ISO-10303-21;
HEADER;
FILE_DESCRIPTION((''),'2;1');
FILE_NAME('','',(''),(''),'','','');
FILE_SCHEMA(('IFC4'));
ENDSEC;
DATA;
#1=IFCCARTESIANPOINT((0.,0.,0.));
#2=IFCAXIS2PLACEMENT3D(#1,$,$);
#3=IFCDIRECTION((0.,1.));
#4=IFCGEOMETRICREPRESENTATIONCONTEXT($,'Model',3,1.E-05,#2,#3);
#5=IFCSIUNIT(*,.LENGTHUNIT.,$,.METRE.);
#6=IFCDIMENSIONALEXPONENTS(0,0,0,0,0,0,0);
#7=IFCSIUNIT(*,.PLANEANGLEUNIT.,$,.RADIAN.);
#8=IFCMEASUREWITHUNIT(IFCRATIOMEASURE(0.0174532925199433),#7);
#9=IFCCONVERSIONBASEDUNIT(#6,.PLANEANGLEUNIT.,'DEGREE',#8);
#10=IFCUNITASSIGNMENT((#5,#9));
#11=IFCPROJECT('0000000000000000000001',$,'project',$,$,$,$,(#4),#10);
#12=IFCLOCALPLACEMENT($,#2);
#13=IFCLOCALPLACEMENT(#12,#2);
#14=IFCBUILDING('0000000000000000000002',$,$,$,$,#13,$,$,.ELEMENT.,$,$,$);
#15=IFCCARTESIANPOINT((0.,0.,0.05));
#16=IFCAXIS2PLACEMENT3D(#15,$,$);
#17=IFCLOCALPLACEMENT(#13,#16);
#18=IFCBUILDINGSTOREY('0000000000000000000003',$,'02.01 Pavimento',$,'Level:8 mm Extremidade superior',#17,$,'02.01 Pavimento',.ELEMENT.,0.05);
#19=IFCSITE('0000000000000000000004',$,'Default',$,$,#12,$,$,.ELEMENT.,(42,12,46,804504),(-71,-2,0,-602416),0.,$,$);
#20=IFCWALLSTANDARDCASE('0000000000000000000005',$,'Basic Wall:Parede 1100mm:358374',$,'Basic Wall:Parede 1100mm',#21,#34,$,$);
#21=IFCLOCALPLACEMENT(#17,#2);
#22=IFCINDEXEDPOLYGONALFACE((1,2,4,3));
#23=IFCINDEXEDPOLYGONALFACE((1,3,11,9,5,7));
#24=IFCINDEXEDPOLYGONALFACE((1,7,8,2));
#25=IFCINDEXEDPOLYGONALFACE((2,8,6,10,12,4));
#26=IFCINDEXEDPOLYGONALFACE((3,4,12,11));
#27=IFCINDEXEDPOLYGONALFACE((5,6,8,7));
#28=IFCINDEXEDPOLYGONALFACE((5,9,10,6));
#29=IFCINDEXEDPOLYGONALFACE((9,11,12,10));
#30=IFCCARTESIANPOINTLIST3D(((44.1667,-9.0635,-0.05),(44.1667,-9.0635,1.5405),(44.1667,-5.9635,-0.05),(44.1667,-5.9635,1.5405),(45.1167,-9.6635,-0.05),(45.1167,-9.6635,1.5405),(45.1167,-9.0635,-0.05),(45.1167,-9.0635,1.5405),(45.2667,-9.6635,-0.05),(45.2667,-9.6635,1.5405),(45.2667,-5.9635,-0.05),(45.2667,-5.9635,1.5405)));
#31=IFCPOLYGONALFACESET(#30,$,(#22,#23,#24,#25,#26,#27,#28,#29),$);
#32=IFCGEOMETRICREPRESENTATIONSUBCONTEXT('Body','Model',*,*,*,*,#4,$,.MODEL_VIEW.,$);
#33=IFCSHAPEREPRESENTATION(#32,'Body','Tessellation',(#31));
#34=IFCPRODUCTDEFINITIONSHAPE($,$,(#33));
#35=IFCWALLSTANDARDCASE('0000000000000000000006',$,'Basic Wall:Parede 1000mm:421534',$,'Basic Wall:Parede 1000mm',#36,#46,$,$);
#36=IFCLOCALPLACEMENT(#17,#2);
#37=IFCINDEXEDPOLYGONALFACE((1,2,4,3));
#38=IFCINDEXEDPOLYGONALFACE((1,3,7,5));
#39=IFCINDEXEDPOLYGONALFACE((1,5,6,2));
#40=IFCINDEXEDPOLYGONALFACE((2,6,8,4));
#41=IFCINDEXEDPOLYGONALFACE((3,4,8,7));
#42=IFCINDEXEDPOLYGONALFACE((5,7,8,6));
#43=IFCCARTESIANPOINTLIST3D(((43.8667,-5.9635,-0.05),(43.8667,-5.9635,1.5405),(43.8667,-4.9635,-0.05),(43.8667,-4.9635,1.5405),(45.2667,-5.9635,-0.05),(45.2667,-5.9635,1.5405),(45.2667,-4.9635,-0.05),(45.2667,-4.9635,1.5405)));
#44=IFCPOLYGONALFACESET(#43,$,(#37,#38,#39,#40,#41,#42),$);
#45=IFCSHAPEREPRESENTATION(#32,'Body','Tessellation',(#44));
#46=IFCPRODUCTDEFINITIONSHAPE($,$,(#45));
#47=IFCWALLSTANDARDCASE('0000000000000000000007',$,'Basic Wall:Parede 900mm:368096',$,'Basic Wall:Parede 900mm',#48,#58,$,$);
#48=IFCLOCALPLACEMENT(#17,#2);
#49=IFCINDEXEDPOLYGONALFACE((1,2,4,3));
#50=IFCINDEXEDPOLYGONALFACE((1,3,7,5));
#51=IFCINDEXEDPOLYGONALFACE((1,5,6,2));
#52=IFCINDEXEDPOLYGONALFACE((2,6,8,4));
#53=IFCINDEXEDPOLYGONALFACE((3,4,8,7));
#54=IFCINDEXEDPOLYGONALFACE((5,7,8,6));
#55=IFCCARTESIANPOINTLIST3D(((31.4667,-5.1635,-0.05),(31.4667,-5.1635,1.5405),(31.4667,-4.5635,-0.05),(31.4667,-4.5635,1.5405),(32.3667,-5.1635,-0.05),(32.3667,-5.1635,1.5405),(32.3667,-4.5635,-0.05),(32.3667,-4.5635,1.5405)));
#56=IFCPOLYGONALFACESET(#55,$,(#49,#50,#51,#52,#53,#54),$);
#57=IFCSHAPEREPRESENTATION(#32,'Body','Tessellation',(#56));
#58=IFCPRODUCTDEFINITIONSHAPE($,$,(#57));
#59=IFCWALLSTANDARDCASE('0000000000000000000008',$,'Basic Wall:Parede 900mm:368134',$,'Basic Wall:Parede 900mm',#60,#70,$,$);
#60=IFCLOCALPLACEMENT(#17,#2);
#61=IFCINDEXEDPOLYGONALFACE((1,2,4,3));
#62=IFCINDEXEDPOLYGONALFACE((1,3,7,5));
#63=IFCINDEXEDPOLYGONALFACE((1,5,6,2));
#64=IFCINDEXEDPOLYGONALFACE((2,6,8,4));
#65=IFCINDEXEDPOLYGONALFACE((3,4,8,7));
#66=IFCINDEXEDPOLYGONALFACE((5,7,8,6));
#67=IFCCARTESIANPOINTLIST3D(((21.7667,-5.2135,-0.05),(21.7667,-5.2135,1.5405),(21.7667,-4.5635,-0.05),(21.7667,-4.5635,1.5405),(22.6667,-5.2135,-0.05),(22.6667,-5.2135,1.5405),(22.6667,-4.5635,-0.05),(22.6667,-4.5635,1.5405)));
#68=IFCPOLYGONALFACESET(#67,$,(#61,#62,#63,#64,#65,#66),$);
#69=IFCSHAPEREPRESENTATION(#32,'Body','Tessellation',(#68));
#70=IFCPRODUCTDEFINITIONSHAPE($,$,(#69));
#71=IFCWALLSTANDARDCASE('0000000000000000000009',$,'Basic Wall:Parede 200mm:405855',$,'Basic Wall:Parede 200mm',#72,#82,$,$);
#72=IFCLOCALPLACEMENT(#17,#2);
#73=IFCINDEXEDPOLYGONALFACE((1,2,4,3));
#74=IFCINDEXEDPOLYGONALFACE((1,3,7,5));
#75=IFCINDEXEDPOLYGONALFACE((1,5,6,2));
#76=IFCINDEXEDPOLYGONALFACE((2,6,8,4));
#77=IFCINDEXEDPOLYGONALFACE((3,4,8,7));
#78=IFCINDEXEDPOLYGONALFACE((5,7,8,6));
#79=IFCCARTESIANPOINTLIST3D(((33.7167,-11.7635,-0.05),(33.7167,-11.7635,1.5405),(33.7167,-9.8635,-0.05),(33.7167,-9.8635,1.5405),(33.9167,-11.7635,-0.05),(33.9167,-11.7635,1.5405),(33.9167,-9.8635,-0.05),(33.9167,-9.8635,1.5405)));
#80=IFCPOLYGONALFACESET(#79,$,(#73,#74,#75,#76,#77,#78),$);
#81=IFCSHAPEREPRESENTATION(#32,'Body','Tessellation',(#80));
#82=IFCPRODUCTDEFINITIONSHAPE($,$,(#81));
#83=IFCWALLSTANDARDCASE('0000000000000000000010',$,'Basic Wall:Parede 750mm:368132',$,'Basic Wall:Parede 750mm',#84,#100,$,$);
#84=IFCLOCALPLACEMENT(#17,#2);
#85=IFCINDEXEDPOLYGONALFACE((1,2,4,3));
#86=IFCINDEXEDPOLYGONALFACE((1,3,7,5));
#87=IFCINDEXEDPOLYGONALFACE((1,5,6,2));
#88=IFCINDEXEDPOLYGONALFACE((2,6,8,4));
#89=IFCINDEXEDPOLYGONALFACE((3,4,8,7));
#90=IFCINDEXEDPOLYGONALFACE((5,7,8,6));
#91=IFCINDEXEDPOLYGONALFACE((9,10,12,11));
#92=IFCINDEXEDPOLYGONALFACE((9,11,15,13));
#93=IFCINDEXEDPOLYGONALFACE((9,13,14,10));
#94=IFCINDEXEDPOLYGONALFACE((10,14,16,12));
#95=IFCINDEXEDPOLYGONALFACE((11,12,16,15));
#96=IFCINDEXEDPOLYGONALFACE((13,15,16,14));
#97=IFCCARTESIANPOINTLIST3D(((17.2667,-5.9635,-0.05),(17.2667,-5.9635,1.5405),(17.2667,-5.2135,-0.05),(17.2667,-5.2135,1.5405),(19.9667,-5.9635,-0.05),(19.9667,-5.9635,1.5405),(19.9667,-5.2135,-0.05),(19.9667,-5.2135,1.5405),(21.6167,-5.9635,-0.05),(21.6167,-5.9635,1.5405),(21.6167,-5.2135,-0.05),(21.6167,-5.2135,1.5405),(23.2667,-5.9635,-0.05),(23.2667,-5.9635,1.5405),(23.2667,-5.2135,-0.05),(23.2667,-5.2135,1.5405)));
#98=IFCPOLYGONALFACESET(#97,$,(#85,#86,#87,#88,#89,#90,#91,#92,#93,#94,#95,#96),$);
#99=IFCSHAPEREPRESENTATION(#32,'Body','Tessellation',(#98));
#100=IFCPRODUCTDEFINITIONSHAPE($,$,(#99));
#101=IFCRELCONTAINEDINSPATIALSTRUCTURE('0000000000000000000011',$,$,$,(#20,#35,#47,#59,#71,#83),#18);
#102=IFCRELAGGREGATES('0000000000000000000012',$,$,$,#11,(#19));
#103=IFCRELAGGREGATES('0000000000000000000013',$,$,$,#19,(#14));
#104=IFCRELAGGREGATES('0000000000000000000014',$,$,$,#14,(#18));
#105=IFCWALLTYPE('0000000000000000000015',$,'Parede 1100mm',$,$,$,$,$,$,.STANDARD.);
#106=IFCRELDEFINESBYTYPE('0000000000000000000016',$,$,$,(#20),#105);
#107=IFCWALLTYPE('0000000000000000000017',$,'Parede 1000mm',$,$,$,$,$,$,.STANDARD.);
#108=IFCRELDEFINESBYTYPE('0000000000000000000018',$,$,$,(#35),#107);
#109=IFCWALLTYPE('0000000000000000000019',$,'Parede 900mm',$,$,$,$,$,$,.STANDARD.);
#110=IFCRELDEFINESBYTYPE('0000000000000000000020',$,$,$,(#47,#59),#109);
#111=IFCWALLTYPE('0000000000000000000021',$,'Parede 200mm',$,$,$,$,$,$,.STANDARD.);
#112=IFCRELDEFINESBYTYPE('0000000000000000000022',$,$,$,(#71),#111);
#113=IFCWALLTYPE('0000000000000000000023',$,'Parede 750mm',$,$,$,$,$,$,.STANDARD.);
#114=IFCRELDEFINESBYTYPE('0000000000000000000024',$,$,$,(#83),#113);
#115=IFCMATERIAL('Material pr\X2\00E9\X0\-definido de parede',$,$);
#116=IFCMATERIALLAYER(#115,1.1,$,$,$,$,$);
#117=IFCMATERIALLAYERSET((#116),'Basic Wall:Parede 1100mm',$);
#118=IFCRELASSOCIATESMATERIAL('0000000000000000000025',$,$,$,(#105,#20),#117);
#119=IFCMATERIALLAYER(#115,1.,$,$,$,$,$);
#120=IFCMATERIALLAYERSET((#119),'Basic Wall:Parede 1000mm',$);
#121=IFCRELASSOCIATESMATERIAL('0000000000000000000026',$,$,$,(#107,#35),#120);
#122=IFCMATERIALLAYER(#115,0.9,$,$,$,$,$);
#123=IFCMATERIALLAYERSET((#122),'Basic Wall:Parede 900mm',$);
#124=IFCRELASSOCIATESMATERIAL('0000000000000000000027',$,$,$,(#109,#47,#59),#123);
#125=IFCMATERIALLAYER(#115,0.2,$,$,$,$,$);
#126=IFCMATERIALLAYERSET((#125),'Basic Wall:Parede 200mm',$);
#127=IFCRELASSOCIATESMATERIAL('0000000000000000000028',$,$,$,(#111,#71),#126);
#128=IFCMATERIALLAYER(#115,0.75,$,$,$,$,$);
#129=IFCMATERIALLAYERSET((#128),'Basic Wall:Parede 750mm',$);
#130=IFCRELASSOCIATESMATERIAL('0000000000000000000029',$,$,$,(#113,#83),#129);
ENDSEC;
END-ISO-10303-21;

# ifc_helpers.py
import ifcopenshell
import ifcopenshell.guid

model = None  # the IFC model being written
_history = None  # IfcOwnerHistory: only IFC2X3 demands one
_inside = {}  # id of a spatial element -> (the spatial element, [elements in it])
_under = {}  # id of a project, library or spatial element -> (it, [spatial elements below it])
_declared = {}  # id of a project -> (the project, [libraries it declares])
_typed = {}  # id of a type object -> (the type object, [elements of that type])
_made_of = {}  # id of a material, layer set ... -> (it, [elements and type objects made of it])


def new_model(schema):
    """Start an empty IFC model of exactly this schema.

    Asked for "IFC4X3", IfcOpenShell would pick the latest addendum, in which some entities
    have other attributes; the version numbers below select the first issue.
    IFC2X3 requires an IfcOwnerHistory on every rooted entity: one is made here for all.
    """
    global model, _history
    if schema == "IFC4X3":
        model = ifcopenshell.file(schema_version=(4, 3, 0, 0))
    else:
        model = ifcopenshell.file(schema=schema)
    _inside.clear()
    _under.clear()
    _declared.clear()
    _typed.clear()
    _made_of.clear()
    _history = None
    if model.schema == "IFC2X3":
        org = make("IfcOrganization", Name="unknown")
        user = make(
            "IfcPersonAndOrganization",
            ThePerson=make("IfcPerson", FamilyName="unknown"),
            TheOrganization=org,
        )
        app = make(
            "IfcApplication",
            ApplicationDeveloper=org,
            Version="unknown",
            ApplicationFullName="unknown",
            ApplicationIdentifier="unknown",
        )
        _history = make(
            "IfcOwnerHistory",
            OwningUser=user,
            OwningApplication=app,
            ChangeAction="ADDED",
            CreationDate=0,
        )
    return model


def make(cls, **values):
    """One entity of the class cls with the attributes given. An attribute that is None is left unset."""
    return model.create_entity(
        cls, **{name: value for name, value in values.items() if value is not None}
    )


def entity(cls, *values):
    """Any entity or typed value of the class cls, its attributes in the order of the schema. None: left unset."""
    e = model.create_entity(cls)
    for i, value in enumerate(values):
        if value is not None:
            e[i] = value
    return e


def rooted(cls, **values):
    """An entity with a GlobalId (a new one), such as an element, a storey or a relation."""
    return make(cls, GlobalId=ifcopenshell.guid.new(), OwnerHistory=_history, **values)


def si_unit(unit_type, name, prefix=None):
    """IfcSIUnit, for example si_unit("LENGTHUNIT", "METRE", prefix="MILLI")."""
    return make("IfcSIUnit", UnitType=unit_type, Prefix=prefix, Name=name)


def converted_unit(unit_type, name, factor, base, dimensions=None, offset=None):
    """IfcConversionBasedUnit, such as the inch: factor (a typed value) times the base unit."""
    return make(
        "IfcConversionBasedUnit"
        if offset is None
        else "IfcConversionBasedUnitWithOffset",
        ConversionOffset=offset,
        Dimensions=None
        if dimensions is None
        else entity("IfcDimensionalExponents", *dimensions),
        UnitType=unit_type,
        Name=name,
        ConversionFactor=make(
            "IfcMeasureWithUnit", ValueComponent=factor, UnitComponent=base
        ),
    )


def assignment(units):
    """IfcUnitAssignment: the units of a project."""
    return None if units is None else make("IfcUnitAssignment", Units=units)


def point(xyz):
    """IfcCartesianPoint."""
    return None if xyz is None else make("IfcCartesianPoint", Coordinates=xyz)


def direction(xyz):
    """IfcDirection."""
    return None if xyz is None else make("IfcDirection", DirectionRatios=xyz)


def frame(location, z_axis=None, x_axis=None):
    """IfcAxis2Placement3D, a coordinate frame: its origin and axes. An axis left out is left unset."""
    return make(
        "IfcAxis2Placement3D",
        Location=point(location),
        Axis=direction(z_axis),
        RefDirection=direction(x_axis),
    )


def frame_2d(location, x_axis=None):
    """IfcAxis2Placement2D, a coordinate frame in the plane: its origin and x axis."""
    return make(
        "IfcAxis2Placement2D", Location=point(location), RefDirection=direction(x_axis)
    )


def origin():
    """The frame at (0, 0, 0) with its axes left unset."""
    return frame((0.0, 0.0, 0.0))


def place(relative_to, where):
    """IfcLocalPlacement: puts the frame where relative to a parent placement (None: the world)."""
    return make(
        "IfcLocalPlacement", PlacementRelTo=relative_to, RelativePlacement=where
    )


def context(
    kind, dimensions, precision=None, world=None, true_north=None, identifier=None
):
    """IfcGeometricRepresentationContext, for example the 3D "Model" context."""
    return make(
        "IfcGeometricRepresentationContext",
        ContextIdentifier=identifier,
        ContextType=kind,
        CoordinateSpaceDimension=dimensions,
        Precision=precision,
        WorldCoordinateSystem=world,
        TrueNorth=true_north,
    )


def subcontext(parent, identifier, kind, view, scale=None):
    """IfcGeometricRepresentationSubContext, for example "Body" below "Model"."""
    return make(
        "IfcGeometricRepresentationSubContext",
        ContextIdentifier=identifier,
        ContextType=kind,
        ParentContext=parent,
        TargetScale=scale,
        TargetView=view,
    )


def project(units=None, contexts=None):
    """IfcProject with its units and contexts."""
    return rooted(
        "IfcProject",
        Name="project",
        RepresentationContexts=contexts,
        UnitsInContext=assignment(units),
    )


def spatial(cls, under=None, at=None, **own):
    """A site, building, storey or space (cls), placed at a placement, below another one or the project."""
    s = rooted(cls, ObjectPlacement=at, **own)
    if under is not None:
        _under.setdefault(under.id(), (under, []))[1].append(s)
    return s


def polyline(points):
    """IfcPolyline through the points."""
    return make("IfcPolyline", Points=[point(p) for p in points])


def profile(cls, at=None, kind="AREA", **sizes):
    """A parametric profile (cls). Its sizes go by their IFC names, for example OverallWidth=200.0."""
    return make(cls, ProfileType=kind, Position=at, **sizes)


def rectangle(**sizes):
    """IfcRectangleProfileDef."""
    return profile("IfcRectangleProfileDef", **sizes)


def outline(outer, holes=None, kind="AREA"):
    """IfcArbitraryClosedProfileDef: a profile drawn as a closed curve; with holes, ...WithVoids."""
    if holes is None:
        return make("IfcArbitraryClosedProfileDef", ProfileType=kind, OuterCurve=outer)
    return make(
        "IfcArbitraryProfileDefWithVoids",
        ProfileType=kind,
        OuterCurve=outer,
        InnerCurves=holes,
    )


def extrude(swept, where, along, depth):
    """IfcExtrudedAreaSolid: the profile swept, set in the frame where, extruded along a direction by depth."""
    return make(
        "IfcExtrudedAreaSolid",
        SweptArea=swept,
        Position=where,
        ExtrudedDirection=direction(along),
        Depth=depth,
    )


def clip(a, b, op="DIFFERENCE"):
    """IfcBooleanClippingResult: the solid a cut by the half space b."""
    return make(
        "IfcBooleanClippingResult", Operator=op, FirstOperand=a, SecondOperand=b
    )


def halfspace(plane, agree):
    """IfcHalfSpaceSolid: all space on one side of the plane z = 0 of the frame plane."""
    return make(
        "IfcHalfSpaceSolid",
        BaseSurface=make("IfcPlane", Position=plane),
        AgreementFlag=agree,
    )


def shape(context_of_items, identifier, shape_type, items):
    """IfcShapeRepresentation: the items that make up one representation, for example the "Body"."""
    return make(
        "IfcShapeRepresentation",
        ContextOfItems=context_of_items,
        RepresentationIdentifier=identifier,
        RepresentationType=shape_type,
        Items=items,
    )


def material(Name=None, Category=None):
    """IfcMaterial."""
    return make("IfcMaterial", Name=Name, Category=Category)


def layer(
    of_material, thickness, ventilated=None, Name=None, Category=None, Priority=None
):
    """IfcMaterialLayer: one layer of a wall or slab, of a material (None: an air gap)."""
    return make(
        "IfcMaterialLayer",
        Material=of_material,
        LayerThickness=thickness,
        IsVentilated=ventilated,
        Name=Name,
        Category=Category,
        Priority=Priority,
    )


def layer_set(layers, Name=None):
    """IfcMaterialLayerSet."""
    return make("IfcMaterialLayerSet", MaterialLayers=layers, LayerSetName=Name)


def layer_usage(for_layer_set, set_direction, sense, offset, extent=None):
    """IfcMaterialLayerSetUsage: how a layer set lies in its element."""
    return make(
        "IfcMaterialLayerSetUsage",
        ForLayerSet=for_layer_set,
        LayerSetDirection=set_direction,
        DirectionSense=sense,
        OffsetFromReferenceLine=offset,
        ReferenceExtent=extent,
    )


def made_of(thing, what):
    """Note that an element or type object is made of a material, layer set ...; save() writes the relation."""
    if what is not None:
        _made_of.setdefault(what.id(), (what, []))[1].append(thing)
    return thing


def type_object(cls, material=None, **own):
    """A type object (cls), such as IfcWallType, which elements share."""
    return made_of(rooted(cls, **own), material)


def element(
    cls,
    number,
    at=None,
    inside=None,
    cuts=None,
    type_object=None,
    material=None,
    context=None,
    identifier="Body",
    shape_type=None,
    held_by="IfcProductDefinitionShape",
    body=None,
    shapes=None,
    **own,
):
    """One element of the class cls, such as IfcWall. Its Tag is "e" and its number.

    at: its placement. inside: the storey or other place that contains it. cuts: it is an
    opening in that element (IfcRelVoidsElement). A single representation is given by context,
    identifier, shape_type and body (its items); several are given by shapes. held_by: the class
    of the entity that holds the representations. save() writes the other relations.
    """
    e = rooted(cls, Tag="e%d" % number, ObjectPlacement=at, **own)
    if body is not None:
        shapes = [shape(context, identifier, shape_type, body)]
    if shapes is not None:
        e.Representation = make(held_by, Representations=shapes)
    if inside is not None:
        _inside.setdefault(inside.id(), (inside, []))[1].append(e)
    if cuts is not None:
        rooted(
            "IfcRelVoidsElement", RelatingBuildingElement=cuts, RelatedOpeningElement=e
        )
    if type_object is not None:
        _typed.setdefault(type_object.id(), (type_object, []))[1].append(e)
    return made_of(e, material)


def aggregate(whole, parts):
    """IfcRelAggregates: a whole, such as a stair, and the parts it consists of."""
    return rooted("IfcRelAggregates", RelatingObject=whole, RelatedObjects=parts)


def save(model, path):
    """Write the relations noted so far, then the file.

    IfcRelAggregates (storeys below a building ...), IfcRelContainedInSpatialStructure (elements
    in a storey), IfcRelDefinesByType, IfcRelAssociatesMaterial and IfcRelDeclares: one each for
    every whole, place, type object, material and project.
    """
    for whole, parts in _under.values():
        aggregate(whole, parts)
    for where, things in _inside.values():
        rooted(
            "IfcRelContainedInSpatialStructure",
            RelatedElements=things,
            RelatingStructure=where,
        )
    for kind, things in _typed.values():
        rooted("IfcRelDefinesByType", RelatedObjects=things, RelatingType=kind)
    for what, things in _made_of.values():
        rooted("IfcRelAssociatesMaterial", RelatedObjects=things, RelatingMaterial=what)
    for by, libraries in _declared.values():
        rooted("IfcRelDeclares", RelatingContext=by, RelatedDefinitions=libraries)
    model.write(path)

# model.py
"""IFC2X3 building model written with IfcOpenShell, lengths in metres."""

from ifc_helpers import new_model, entity, si_unit, converted_unit, direction, frame, frame_2d, origin, place, context, subcontext, project, spatial, polyline, rectangle, outline, extrude, clip, halfspace, material, layer, layer_set, layer_usage, type_object, element, save


model = new_model("IFC2X3")

# Units and contexts
model_context = context("Model", 3, precision=1e-05, world=origin(), true_north=direction((0.0, 1.0)))
body_context = subcontext(model_context, "Body", "Model", "MODEL_VIEW")
ifc_project = project(units=[si_unit("LENGTHUNIT", "METRE"), converted_unit("PLANEANGLEUNIT", "DEGREE", entity("IfcRatioMeasure", 0.0174532925199433), si_unit("PLANEANGLEUNIT", "RADIAN"), dimensions=[0, 0, 0, 0, 0, 0, 0])], contexts=[model_context])

# Site, building, storey
site_placement = place(None, origin())
site = spatial("IfcSite", under=ifc_project, at=site_placement, Name="Default", CompositionType="ELEMENT", RefLatitude=(42, 12, 46, 804504), RefLongitude=(-71, -2, 0, -602416), RefElevation=0.0)
building_placement = place(site_placement, origin())
building = spatial("IfcBuilding", under=site, at=building_placement, CompositionType="ELEMENT")
storey_placement = place(building_placement, frame((0.0, 0.0, 0.05)))
storey = spatial("IfcBuildingStorey", under=building, at=storey_placement, Name="02.01 Pavimento", ObjectType="Level:8 mm Extremidade superior", LongName="02.01 Pavimento", CompositionType="ELEMENT", Elevation=0.05)

# Wall
ifc_material_1 = material(Name="Material pré-definido de parede")
ifc_layer_1 = layer(ifc_material_1, 1.1)
ifc_layer_set_1 = layer_set([ifc_layer_1], Name="Basic Wall:Parede 1100mm")
ifc_layer_usage_1 = layer_usage(ifc_layer_set_1, "AXIS2", "POSITIVE", -0.55)
wall_type_1 = type_object("IfcWallType", Name="Parede 1100mm", PredefinedType="STANDARD", material=ifc_layer_set_1)
wall_1_placement = place(storey_placement, frame((44.7167, -9.0635, -0.05), z_axis=(0.0, 0.0, 1.0), x_axis=(0.0, 1.0, 0.0)))
element("IfcWallStandardCase", 1, at=wall_1_placement, inside=storey, type_object=wall_type_1, material=ifc_layer_usage_1, Name="Basic Wall:Parede 1100mm:358374", ObjectType="Basic Wall:Parede 1100mm", context=body_context, shape_type="Clipping", body=[
    clip(extrude(outline(polyline([(-0.6, -0.55), (3.1, -0.55), (3.1, 0.55), (0.0, 0.55), (0.0, -0.4), (-0.6, -0.4), (-0.6, -0.55)])), origin(), (0.0, 0.0, 1.0), 1.5905), halfspace(frame((0.0, 0.0, -0.05)), True)),
])

# Walls
ifc_layer_2 = layer(ifc_material_1, 1.0)
ifc_layer_set_2 = layer_set([ifc_layer_2], Name="Basic Wall:Parede 1000mm")
ifc_layer_usage_2 = layer_usage(ifc_layer_set_2, "AXIS2", "POSITIVE", -0.5)
wall_type_2 = type_object("IfcWallType", Name="Parede 1000mm", PredefinedType="STANDARD", material=ifc_layer_set_2)
wall_2_placement = place(storey_placement, frame((43.8667, -5.4635, -0.05)))
element("IfcWallStandardCase", 2, at=wall_2_placement, inside=storey, type_object=wall_type_2, material=ifc_layer_usage_2, Name="Basic Wall:Parede 1000mm:421534", ObjectType="Basic Wall:Parede 1000mm", context=body_context, shape_type="Clipping", body=[
    clip(extrude(rectangle(XDim=1.4, YDim=1.0, at=frame_2d((0.7, 0.0), x_axis=(-1.0, 0.0))), origin(), (0.0, 0.0, 1.0), 1.5905), halfspace(frame((0.0, 0.0, -0.05)), True)),
])
ifc_layer_3 = layer(ifc_material_1, 0.9)
ifc_layer_set_3 = layer_set([ifc_layer_3], Name="Basic Wall:Parede 900mm")
ifc_layer_usage_3 = layer_usage(ifc_layer_set_3, "AXIS2", "POSITIVE", -0.45)
wall_type_3 = type_object("IfcWallType", Name="Parede 900mm", PredefinedType="STANDARD", material=ifc_layer_set_3)
wall_3_placement = place(storey_placement, frame((31.9167, -4.5635, -0.05), z_axis=(0.0, 0.0, 1.0), x_axis=(0.0, -1.0, 0.0)))
element("IfcWallStandardCase", 3, at=wall_3_placement, inside=storey, type_object=wall_type_3, material=ifc_layer_usage_3, Name="Basic Wall:Parede 900mm:368096", ObjectType="Basic Wall:Parede 900mm", context=body_context, shape_type="Clipping", body=[
    clip(extrude(rectangle(XDim=0.6, YDim=0.9, at=frame_2d((0.3, 0.0), x_axis=(-1.0, 0.0))), origin(), (0.0, 0.0, 1.0), 1.5905), halfspace(frame((0.0, 0.0, -0.05)), True)),
])
ifc_layer_usage_4 = layer_usage(ifc_layer_set_3, "AXIS2", "NEGATIVE", 0.45)
wall_4_placement = place(storey_placement, frame((22.2167, -4.5635, -0.05), z_axis=(0.0, 0.0, 1.0), x_axis=(0.0, -1.0, 0.0)))
element("IfcWallStandardCase", 4, at=wall_4_placement, inside=storey, type_object=wall_type_3, material=ifc_layer_usage_4, Name="Basic Wall:Parede 900mm:368134", ObjectType="Basic Wall:Parede 900mm", context=body_context, shape_type="Clipping", body=[
    clip(extrude(rectangle(XDim=0.65, YDim=0.9, at=frame_2d((0.325, 0.0), x_axis=(-1.0, 0.0))), origin(), (0.0, 0.0, 1.0), 1.5905), halfspace(frame((0.0, 0.0, -0.05)), True)),
])
ifc_layer_4 = layer(ifc_material_1, 0.2)
ifc_layer_set_4 = layer_set([ifc_layer_4], Name="Basic Wall:Parede 200mm")
ifc_layer_usage_5 = layer_usage(ifc_layer_set_4, "AXIS2", "POSITIVE", -0.1)
wall_type_4 = type_object("IfcWallType", Name="Parede 200mm", PredefinedType="STANDARD", material=ifc_layer_set_4)
wall_5_placement = place(storey_placement, frame((33.8167, -12.4635, -0.05), z_axis=(0.0, 0.0, 1.0), x_axis=(0.0, 1.0, 0.0)))
element("IfcWallStandardCase", 5, at=wall_5_placement, inside=storey, type_object=wall_type_4, material=ifc_layer_usage_5, Name="Basic Wall:Parede 200mm:405855", ObjectType="Basic Wall:Parede 200mm", context=body_context, shape_type="SweptSolid", body=[
    extrude(rectangle(XDim=0.2, YDim=1.9, at=frame_2d((0.0, 0.0), x_axis=(1.0, 0.0))), frame((1.65, 0.0, 0.0), z_axis=(0.0, 0.0, 1.0), x_axis=(0.0, 1.0, 0.0)), (0.0, 0.0, 1.0), 1.5905),
])

# Wall, opening
ifc_layer_5 = layer(ifc_material_1, 0.75)
ifc_layer_set_5 = layer_set([ifc_layer_5], Name="Basic Wall:Parede 750mm")
ifc_layer_usage_6 = layer_usage(ifc_layer_set_5, "AXIS2", "POSITIVE", -0.375)
wall_type_5 = type_object("IfcWallType", Name="Parede 750mm", PredefinedType="STANDARD", material=ifc_layer_set_5)
wall_6_placement = place(storey_placement, frame((17.2667, -5.5885, -0.05)))
wall_6 = element("IfcWallStandardCase", 6, at=wall_6_placement, inside=storey, type_object=wall_type_5, material=ifc_layer_usage_6, Name="Basic Wall:Parede 750mm:368132", ObjectType="Basic Wall:Parede 750mm", context=body_context, shape_type="Clipping", body=[
    clip(extrude(rectangle(XDim=6.0, YDim=0.75, at=frame_2d((3.0, 0.0), x_axis=(-1.0, 0.0))), origin(), (0.0, 0.0, 1.0), 1.5905), halfspace(frame((0.0, 0.0, -0.05)), True)),
])
opening_1_placement = place(wall_6_placement, frame((2.7, -1.149, 0.0)))
element("IfcOpeningElement", 7, at=opening_1_placement, cuts=wall_6, ObjectType="Opening", context=body_context, shape_type="SweptSolid", body=[
    extrude(rectangle(XDim=3.4, YDim=1.65, at=frame_2d((0.0, 0.0), x_axis=(0.0, 1.0))), frame((0.825, 0.0, 1.7), z_axis=(0.0, 1.0, 0.0), x_axis=(-1.0, 0.0, 0.0)), (0.0, 0.0, 1.0), 3.048),
])

save(model, "model.ifc")
